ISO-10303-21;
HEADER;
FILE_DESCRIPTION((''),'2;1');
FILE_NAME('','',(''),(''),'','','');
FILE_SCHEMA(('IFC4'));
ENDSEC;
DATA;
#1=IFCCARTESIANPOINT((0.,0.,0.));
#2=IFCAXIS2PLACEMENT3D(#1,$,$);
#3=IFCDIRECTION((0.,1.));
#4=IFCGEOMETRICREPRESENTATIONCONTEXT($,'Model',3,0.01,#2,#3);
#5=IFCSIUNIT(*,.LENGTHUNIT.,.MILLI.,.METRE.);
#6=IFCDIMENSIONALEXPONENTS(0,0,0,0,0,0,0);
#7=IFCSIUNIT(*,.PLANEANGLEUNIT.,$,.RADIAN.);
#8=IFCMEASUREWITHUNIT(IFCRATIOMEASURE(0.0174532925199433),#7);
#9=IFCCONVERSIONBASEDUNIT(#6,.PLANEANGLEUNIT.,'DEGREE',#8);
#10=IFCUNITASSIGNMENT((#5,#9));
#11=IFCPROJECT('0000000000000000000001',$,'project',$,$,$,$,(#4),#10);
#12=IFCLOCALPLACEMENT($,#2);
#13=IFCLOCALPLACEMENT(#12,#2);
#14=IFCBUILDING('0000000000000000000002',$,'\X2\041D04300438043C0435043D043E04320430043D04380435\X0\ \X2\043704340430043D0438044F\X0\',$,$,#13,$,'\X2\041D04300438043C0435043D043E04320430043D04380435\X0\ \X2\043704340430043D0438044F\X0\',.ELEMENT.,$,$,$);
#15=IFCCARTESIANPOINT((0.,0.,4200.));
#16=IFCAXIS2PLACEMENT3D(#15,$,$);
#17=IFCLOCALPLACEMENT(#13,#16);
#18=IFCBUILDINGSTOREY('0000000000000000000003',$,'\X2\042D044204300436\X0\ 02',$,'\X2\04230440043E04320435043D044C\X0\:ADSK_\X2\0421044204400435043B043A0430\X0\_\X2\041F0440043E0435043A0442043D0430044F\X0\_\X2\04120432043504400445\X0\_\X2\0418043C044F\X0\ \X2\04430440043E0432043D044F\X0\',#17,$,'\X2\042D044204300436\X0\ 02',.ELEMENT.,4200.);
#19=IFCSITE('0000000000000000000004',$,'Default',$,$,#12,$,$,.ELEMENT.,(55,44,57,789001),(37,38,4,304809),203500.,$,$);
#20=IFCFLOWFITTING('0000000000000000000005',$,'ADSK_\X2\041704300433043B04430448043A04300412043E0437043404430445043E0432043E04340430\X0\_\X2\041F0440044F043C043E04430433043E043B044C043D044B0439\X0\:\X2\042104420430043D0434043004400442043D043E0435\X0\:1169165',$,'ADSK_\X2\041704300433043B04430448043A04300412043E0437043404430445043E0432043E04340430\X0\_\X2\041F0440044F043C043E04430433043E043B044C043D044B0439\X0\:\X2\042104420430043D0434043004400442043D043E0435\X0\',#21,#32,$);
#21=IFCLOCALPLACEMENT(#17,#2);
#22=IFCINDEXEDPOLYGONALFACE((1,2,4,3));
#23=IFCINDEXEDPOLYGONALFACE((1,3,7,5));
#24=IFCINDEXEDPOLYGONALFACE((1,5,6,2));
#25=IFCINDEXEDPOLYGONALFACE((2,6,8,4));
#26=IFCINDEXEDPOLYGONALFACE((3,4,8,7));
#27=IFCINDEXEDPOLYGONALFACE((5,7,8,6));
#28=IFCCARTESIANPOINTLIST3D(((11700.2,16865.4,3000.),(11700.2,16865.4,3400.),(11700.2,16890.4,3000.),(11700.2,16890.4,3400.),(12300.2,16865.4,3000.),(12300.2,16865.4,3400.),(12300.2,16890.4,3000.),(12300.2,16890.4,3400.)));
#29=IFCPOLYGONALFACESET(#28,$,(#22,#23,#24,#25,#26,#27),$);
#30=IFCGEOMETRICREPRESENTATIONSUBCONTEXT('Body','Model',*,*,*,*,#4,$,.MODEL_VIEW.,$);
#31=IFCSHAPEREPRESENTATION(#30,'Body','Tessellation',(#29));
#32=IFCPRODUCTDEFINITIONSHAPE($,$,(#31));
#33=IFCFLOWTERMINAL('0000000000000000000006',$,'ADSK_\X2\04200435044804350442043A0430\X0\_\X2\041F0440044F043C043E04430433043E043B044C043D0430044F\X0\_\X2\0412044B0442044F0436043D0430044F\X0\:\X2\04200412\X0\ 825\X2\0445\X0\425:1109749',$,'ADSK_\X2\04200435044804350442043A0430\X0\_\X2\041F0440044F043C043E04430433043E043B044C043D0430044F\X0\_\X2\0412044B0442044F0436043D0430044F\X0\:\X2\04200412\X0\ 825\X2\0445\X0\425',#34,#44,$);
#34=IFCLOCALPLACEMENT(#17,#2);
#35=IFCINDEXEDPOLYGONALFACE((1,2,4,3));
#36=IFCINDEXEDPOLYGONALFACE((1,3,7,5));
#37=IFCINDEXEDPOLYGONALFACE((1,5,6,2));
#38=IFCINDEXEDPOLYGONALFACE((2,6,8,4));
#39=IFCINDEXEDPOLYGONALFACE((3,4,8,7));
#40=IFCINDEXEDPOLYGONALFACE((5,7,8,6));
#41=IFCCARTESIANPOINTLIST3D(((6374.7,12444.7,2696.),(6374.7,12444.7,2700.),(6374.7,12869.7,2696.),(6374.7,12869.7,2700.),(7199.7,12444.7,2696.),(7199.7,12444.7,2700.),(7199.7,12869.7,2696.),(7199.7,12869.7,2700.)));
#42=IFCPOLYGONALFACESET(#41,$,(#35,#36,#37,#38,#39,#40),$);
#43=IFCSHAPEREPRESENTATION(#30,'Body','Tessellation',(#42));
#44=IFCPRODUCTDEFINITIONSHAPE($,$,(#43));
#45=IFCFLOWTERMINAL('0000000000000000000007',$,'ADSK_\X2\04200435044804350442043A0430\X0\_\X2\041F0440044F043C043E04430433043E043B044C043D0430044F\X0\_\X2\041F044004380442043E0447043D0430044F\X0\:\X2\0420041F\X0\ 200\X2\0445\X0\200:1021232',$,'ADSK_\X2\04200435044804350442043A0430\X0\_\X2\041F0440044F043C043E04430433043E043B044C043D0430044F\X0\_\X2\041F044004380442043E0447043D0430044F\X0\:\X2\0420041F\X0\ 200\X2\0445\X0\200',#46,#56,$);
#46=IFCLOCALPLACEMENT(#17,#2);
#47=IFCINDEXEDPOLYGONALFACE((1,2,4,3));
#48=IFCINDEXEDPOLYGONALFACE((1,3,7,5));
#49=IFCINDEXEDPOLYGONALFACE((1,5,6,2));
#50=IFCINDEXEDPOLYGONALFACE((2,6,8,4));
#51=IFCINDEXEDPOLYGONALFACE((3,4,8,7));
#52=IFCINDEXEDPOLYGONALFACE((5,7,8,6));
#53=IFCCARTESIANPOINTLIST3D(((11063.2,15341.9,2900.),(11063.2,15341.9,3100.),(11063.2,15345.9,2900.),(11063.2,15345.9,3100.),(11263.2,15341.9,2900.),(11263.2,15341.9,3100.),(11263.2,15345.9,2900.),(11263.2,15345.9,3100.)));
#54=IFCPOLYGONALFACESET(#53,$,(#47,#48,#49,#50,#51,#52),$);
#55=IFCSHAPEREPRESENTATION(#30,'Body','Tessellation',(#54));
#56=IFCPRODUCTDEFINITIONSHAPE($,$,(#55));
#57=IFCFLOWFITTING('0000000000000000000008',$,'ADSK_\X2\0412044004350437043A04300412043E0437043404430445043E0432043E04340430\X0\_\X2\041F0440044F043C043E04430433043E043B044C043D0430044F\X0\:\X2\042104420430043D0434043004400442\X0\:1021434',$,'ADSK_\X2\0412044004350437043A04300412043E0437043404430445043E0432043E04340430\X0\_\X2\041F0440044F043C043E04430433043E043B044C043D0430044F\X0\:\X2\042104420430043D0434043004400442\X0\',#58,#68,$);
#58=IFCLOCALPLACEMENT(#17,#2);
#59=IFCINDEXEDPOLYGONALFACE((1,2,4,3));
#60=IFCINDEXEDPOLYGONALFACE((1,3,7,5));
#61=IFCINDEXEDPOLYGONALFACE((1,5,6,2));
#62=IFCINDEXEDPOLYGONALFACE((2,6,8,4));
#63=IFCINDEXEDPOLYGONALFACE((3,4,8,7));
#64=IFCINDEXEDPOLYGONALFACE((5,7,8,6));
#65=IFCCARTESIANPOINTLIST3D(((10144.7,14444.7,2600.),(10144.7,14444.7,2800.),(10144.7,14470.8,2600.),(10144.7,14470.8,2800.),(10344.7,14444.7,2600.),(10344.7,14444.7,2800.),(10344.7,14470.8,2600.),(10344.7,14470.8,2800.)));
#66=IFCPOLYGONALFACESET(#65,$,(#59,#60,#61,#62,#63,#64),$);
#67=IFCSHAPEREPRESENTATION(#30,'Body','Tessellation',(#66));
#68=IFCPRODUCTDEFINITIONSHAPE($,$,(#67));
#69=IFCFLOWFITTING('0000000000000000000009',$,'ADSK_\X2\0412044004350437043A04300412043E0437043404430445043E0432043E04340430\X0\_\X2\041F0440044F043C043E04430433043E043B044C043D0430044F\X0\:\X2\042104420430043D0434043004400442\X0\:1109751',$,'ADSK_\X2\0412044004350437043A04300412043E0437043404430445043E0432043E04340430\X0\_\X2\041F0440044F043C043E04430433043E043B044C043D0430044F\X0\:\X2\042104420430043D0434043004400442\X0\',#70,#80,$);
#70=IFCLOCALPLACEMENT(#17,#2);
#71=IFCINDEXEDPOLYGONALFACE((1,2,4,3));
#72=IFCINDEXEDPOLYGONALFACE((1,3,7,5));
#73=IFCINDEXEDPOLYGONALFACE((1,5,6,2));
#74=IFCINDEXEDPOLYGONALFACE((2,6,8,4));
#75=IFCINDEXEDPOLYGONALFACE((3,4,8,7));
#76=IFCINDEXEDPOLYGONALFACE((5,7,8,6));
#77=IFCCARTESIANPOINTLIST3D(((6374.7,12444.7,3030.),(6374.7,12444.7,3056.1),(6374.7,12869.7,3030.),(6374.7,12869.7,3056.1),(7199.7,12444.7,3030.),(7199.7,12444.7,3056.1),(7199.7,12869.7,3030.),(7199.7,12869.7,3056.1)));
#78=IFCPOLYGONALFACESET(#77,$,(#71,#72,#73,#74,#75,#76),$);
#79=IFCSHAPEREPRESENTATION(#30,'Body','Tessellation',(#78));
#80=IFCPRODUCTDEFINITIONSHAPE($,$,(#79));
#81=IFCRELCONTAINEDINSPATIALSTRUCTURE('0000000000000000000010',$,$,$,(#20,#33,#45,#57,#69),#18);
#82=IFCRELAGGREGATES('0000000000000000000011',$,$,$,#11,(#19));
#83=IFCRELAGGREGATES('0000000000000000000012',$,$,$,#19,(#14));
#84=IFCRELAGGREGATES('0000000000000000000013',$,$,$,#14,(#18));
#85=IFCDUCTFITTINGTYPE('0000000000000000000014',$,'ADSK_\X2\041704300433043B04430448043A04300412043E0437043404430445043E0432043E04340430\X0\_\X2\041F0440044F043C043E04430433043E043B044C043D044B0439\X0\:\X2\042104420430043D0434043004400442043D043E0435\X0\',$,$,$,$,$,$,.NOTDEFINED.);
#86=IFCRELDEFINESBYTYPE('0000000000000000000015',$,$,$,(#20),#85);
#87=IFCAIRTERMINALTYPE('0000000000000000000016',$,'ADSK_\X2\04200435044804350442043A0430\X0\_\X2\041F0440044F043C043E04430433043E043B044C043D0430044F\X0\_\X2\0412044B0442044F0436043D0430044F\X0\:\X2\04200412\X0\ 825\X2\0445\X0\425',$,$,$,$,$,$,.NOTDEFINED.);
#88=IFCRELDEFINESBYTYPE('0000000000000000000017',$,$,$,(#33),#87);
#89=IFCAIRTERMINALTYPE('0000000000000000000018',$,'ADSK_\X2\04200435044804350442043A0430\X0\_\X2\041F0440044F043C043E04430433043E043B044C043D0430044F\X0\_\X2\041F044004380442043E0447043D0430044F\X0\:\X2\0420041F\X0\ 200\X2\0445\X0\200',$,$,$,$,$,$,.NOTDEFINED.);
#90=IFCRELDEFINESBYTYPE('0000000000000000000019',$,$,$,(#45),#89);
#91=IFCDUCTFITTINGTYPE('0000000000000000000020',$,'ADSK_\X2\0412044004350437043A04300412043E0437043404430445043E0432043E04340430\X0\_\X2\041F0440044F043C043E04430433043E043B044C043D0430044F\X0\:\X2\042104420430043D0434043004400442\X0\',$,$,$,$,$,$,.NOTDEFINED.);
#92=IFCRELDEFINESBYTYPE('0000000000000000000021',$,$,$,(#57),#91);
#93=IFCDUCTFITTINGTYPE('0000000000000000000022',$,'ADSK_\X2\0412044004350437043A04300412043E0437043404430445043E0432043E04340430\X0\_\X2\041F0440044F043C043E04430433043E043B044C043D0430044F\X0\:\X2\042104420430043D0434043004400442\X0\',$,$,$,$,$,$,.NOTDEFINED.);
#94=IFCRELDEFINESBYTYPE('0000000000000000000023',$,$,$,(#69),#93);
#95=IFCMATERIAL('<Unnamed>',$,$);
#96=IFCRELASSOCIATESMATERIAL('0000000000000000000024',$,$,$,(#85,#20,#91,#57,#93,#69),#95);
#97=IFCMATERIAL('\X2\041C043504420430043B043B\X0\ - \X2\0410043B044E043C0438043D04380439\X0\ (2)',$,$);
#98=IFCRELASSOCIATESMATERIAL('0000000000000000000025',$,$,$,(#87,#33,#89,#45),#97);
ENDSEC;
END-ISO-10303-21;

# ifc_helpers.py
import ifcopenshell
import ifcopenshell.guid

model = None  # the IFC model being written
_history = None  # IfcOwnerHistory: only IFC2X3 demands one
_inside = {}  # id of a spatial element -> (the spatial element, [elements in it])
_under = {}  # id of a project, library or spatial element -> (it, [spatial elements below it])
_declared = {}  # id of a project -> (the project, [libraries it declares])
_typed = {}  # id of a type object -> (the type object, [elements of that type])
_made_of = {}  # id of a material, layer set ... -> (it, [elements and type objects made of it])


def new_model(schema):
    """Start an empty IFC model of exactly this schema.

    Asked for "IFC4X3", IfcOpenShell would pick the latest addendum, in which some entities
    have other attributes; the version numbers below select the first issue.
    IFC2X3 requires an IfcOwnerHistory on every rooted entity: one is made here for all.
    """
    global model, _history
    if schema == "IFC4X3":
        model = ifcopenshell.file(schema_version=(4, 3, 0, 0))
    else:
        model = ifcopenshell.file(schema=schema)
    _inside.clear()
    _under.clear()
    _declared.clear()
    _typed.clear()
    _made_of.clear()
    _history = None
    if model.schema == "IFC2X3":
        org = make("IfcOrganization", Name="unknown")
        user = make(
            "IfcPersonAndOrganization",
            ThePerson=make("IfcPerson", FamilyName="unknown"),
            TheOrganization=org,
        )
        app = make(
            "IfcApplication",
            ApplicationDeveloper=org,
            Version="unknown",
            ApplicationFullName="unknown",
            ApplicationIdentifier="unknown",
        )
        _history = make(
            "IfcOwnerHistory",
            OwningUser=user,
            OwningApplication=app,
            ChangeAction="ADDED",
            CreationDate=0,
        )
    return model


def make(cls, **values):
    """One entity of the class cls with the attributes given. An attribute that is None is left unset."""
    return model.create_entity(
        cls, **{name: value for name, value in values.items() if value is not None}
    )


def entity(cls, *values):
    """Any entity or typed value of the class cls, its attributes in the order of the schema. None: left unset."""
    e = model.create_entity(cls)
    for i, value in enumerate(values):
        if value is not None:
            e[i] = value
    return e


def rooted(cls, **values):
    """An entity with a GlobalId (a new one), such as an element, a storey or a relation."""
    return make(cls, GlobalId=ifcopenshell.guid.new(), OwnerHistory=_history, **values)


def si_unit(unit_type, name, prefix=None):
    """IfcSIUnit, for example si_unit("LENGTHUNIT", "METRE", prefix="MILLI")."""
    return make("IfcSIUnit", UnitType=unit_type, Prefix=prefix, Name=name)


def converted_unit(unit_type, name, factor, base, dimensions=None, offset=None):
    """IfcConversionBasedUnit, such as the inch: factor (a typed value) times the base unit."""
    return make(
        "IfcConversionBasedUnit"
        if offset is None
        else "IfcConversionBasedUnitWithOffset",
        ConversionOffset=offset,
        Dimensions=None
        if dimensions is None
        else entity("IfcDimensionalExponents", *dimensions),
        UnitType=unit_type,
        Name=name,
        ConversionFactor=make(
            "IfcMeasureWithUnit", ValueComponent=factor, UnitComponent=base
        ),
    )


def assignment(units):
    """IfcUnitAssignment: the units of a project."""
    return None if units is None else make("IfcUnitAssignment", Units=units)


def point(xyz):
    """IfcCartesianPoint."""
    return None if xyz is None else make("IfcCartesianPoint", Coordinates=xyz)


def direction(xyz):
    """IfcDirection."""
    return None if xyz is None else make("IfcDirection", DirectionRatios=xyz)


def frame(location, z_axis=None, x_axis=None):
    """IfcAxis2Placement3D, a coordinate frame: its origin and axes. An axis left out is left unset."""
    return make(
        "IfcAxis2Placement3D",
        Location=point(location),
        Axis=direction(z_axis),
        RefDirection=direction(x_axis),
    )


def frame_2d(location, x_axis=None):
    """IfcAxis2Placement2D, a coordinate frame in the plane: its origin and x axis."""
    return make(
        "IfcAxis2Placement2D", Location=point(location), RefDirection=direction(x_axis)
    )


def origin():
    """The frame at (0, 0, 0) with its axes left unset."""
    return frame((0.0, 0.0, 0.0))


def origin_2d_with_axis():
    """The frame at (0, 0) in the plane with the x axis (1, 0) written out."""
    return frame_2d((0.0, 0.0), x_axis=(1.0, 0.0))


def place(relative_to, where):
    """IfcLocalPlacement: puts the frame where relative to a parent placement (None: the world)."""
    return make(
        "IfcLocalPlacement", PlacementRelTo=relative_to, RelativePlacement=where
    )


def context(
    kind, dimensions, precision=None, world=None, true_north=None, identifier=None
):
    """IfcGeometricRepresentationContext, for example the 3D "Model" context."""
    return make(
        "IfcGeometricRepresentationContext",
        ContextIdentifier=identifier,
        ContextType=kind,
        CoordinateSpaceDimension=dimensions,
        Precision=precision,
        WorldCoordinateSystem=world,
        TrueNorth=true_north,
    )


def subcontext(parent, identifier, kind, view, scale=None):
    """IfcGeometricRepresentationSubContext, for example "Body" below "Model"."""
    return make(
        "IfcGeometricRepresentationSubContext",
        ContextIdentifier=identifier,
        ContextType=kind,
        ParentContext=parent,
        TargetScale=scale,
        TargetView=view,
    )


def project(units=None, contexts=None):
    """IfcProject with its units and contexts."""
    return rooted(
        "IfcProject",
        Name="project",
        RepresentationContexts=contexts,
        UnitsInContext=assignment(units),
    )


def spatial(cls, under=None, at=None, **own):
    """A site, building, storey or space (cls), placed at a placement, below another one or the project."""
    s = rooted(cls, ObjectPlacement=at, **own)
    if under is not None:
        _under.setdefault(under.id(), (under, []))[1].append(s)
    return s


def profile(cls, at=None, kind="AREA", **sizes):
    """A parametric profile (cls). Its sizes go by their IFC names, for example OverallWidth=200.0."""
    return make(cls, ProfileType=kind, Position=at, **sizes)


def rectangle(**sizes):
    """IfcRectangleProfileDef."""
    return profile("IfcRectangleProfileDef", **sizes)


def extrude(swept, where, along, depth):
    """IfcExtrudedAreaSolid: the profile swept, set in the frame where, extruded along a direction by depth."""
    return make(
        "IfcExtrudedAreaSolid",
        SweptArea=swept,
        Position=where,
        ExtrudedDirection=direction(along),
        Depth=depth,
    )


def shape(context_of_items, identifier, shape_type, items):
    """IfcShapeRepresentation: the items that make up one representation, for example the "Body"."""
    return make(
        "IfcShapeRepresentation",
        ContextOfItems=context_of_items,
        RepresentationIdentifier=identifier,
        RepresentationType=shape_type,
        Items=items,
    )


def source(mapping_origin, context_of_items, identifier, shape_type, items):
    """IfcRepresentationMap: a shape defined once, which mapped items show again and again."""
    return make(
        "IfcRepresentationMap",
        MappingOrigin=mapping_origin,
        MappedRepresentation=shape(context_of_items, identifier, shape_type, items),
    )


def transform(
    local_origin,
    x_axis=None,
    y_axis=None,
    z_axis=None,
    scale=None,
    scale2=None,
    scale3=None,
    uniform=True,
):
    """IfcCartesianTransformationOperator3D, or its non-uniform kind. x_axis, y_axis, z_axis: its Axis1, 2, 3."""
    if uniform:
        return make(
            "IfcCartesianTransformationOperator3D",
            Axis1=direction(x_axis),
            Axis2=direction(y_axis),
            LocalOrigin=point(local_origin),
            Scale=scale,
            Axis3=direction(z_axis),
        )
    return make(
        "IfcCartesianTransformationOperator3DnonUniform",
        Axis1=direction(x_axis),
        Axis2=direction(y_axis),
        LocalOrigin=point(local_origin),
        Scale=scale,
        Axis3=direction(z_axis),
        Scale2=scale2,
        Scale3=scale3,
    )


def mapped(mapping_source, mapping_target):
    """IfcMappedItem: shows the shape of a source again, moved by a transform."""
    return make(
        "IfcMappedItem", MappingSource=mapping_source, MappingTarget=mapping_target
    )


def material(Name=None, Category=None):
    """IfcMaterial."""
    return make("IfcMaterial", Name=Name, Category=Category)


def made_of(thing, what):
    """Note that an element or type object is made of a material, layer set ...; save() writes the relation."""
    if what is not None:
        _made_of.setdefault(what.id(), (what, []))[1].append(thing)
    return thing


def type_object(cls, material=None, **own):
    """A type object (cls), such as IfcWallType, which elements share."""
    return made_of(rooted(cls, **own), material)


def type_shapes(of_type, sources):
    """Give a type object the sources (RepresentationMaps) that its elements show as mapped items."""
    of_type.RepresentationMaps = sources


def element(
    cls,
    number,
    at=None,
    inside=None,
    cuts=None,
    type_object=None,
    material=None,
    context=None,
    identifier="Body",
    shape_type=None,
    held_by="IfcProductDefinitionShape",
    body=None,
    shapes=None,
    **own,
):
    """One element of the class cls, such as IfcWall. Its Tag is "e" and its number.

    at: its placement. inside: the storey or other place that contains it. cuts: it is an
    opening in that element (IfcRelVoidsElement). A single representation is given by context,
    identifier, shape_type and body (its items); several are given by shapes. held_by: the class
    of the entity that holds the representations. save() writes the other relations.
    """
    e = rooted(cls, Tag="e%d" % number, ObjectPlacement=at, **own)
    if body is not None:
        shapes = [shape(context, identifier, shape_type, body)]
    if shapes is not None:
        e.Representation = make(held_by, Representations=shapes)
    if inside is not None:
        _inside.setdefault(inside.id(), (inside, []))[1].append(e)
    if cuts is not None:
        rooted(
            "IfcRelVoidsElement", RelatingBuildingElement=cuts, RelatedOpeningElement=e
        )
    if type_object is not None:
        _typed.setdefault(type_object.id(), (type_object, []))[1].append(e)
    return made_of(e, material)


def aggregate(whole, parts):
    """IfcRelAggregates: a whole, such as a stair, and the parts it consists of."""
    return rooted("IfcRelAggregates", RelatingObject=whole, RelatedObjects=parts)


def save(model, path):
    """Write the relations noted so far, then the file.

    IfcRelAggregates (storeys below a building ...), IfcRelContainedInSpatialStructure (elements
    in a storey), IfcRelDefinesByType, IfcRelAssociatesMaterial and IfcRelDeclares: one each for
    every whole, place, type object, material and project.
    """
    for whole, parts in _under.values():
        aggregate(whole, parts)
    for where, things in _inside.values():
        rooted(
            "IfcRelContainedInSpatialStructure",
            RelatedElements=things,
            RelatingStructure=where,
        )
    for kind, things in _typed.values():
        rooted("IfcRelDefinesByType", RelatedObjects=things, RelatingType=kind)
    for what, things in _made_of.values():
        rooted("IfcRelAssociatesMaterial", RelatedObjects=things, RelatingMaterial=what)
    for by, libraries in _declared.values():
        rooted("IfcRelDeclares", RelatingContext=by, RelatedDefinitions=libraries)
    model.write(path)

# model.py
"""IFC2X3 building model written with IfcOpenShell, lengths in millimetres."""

from ifc_helpers import new_model, entity, si_unit, converted_unit, direction, frame, frame_2d, origin, origin_2d_with_axis, place, context, subcontext, project, spatial, rectangle, extrude, source, transform, mapped, material, type_object, type_shapes, element, save


model = new_model("IFC2X3")

# Units and contexts
model_context = context("Model", 3, precision=0.01, world=origin(), true_north=direction((0.0, 1.0)))
body_context = subcontext(model_context, "Body", "Model", "MODEL_VIEW")
ifc_project = project(units=[si_unit("LENGTHUNIT", "METRE", prefix="MILLI"), converted_unit("PLANEANGLEUNIT", "DEGREE", entity("IfcRatioMeasure", 0.0174532925199433), si_unit("PLANEANGLEUNIT", "RADIAN"), dimensions=[0, 0, 0, 0, 0, 0, 0])], contexts=[model_context])

# Site, building, storey
site_placement = place(None, frame((0.0, 0.0, 0.0)))
site = spatial("IfcSite", under=ifc_project, at=site_placement, Name="Default", CompositionType="ELEMENT", RefLatitude=(55, 44, 57, 789001), RefLongitude=(37, 38, 4, 304809), RefElevation=203500.0)
building_placement = place(site_placement, origin())
building = spatial("IfcBuilding", under=site, at=building_placement, Name="Наименование здания", LongName="Наименование здания", CompositionType="ELEMENT")
storey_placement = place(building_placement, frame((0.0, 0.0, 4200.0)))
storey = spatial("IfcBuildingStorey", under=building, at=storey_placement, Name="Этаж 02", ObjectType="Уровень:ADSK_Стрелка_Проектная_Вверх_Имя уровня", LongName="Этаж 02", CompositionType="ELEMENT", Elevation=4200.0)

# Flow fitting
ifc_material_1 = material(Name="<Unnamed>")
duct_fitting_type_1 = type_object("IfcDuctFittingType", Name="ADSK_ЗаглушкаВоздуховода_Прямоугольный:Стандартное", PredefinedType="NOTDEFINED", material=ifc_material_1)
shared_shape_1 = source(origin(), body_context, "Body", "SweptSolid", [
    extrude(rectangle(XDim=25.0, YDim=600.0, at=frame_2d((0.0, 0.0), x_axis=(1.0, 0.0))), frame((12.5, 0.0, -200.0)), (0.0, 0.0, 1.0), 400.0),
])
type_shapes(duct_fitting_type_1, [shared_shape_1])
flow_fitting_1_placement = place(storey_placement, frame((12000.2, 16865.4, 3200.0), z_axis=(0.0, 0.0, 1.0), x_axis=(0.0, 1.0, 0.0)))
element("IfcFlowFitting", 1, at=flow_fitting_1_placement, inside=storey, type_object=duct_fitting_type_1, material=ifc_material_1, Name="ADSK_ЗаглушкаВоздуховода_Прямоугольный:Стандартное:1169165", ObjectType="ADSK_ЗаглушкаВоздуховода_Прямоугольный:Стандартное", context=body_context, shape_type="MappedRepresentation", body=[
    mapped(shared_shape_1, transform((0.0, 0.0, 0.0), scale=1.0)),
])

# Flow terminal
ifc_material_2 = material(Name="Металл - Алюминий (2)")
air_terminal_type_1 = type_object("IfcAirTerminalType", Name="ADSK_Решетка_Прямоугольная_Вытяжная:РВ 825х425", PredefinedType="NOTDEFINED", material=ifc_material_2)
shared_shape_2 = source(origin(), body_context, "Body", "SweptSolid", [
    extrude(rectangle(XDim=4.0, YDim=825.0, at=origin_2d_with_axis()), frame((0.0, -2.0, -212.5), z_axis=(0.0, 0.0, 1.0), x_axis=(0.0, 1.0, 0.0)), (0.0, 0.0, 1.0), 425.0),
])
type_shapes(air_terminal_type_1, [shared_shape_2])
flow_terminal_1_placement = place(storey_placement, frame((6787.2, 12657.2, 2700.0), z_axis=(0.0, 1.0, 0.0), x_axis=(-1.0, 0.0, 0.0)))
element("IfcFlowTerminal", 2, at=flow_terminal_1_placement, inside=storey, type_object=air_terminal_type_1, material=ifc_material_2, Name="ADSK_Решетка_Прямоугольная_Вытяжная:РВ 825х425:1109749", ObjectType="ADSK_Решетка_Прямоугольная_Вытяжная:РВ 825х425", context=body_context, shape_type="MappedRepresentation", body=[
    mapped(shared_shape_2, transform((0.0, 0.0, 0.0), scale=1.0)),
])

# Flow terminal
air_terminal_type_2 = type_object("IfcAirTerminalType", Name="ADSK_Решетка_Прямоугольная_Приточная:РП 200х200", PredefinedType="NOTDEFINED", material=ifc_material_2)
shared_shape_3 = source(origin(), body_context, "Body", "SweptSolid", [
    extrude(rectangle(XDim=4.0, YDim=200.0, at=origin_2d_with_axis()), frame((0.0, -2.0, -100.0), z_axis=(0.0, 0.0, 1.0), x_axis=(0.0, 1.0, 0.0)), (0.0, 0.0, 1.0), 200.0),
])
type_shapes(air_terminal_type_2, [shared_shape_3])
flow_terminal_2_placement = place(storey_placement, frame((11163.2, 15341.9, 3000.0), z_axis=(0.0, 0.0, 1.0), x_axis=(-1.0, 0.0, 0.0)))
element("IfcFlowTerminal", 3, at=flow_terminal_2_placement, inside=storey, type_object=air_terminal_type_2, material=ifc_material_2, Name="ADSK_Решетка_Прямоугольная_Приточная:РП 200х200:1021232", ObjectType="ADSK_Решетка_Прямоугольная_Приточная:РП 200х200", context=body_context, shape_type="MappedRepresentation", body=[
    mapped(shared_shape_3, transform((0.0, 0.0, 0.0), scale=1.0)),
])

# Flow fittings
duct_fitting_type_2 = type_object("IfcDuctFittingType", Name="ADSK_ВрезкаВоздуховода_Прямоугольная:Стандарт", PredefinedType="NOTDEFINED", material=ifc_material_1)
shared_shape_4 = source(origin(), body_context, "Body", "SweptSolid", [
    extrude(rectangle(XDim=26.1, YDim=200.0, at=frame_2d((0.0, 0.0), x_axis=(1.0, 0.0))), frame((7.0, 0.0, -100.0)), (0.0, 0.0, 1.0), 200.0),
])
type_shapes(duct_fitting_type_2, [shared_shape_4])
flow_fitting_2_placement = place(storey_placement, frame((10244.7, 14450.8, 2700.0), z_axis=(1.0, 0.0, 0.0), x_axis=(0.0, 1.0, 0.0)))
element("IfcFlowFitting", 4, at=flow_fitting_2_placement, inside=storey, type_object=duct_fitting_type_2, material=ifc_material_1, Name="ADSK_ВрезкаВоздуховода_Прямоугольная:Стандарт:1021434", ObjectType="ADSK_ВрезкаВоздуховода_Прямоугольная:Стандарт", context=body_context, shape_type="MappedRepresentation", body=[
    mapped(shared_shape_4, transform((0.0, 0.0, 0.0), scale=1.0)),
])
duct_fitting_type_3 = type_object("IfcDuctFittingType", Name="ADSK_ВрезкаВоздуховода_Прямоугольная:Стандарт", PredefinedType="NOTDEFINED", material=ifc_material_1)
shared_shape_5 = source(origin(), body_context, "Body", "SweptSolid", [
    extrude(rectangle(XDim=825.0, YDim=26.1, at=frame_2d((0.0, 0.0), x_axis=(1.0, 0.0))), frame((7.0, 0.0, -212.5), z_axis=(0.0, 0.0, 1.0), x_axis=(0.0, -1.0, 0.0)), (0.0, 0.0, 1.0), 425.0),
])
type_shapes(duct_fitting_type_3, [shared_shape_5])
flow_fitting_3_placement = place(storey_placement, frame((6787.2, 12657.2, 3050.0), z_axis=(0.0, -1.0, 0.0), x_axis=(0.0, 0.0, -1.0)))
element("IfcFlowFitting", 5, at=flow_fitting_3_placement, inside=storey, type_object=duct_fitting_type_3, material=ifc_material_1, Name="ADSK_ВрезкаВоздуховода_Прямоугольная:Стандарт:1109751", ObjectType="ADSK_ВрезкаВоздуховода_Прямоугольная:Стандарт", context=body_context, shape_type="MappedRepresentation", body=[
    mapped(shared_shape_5, transform((0.0, 0.0, 0.0), scale=1.0)),
])

save(model, "model.ifc")
